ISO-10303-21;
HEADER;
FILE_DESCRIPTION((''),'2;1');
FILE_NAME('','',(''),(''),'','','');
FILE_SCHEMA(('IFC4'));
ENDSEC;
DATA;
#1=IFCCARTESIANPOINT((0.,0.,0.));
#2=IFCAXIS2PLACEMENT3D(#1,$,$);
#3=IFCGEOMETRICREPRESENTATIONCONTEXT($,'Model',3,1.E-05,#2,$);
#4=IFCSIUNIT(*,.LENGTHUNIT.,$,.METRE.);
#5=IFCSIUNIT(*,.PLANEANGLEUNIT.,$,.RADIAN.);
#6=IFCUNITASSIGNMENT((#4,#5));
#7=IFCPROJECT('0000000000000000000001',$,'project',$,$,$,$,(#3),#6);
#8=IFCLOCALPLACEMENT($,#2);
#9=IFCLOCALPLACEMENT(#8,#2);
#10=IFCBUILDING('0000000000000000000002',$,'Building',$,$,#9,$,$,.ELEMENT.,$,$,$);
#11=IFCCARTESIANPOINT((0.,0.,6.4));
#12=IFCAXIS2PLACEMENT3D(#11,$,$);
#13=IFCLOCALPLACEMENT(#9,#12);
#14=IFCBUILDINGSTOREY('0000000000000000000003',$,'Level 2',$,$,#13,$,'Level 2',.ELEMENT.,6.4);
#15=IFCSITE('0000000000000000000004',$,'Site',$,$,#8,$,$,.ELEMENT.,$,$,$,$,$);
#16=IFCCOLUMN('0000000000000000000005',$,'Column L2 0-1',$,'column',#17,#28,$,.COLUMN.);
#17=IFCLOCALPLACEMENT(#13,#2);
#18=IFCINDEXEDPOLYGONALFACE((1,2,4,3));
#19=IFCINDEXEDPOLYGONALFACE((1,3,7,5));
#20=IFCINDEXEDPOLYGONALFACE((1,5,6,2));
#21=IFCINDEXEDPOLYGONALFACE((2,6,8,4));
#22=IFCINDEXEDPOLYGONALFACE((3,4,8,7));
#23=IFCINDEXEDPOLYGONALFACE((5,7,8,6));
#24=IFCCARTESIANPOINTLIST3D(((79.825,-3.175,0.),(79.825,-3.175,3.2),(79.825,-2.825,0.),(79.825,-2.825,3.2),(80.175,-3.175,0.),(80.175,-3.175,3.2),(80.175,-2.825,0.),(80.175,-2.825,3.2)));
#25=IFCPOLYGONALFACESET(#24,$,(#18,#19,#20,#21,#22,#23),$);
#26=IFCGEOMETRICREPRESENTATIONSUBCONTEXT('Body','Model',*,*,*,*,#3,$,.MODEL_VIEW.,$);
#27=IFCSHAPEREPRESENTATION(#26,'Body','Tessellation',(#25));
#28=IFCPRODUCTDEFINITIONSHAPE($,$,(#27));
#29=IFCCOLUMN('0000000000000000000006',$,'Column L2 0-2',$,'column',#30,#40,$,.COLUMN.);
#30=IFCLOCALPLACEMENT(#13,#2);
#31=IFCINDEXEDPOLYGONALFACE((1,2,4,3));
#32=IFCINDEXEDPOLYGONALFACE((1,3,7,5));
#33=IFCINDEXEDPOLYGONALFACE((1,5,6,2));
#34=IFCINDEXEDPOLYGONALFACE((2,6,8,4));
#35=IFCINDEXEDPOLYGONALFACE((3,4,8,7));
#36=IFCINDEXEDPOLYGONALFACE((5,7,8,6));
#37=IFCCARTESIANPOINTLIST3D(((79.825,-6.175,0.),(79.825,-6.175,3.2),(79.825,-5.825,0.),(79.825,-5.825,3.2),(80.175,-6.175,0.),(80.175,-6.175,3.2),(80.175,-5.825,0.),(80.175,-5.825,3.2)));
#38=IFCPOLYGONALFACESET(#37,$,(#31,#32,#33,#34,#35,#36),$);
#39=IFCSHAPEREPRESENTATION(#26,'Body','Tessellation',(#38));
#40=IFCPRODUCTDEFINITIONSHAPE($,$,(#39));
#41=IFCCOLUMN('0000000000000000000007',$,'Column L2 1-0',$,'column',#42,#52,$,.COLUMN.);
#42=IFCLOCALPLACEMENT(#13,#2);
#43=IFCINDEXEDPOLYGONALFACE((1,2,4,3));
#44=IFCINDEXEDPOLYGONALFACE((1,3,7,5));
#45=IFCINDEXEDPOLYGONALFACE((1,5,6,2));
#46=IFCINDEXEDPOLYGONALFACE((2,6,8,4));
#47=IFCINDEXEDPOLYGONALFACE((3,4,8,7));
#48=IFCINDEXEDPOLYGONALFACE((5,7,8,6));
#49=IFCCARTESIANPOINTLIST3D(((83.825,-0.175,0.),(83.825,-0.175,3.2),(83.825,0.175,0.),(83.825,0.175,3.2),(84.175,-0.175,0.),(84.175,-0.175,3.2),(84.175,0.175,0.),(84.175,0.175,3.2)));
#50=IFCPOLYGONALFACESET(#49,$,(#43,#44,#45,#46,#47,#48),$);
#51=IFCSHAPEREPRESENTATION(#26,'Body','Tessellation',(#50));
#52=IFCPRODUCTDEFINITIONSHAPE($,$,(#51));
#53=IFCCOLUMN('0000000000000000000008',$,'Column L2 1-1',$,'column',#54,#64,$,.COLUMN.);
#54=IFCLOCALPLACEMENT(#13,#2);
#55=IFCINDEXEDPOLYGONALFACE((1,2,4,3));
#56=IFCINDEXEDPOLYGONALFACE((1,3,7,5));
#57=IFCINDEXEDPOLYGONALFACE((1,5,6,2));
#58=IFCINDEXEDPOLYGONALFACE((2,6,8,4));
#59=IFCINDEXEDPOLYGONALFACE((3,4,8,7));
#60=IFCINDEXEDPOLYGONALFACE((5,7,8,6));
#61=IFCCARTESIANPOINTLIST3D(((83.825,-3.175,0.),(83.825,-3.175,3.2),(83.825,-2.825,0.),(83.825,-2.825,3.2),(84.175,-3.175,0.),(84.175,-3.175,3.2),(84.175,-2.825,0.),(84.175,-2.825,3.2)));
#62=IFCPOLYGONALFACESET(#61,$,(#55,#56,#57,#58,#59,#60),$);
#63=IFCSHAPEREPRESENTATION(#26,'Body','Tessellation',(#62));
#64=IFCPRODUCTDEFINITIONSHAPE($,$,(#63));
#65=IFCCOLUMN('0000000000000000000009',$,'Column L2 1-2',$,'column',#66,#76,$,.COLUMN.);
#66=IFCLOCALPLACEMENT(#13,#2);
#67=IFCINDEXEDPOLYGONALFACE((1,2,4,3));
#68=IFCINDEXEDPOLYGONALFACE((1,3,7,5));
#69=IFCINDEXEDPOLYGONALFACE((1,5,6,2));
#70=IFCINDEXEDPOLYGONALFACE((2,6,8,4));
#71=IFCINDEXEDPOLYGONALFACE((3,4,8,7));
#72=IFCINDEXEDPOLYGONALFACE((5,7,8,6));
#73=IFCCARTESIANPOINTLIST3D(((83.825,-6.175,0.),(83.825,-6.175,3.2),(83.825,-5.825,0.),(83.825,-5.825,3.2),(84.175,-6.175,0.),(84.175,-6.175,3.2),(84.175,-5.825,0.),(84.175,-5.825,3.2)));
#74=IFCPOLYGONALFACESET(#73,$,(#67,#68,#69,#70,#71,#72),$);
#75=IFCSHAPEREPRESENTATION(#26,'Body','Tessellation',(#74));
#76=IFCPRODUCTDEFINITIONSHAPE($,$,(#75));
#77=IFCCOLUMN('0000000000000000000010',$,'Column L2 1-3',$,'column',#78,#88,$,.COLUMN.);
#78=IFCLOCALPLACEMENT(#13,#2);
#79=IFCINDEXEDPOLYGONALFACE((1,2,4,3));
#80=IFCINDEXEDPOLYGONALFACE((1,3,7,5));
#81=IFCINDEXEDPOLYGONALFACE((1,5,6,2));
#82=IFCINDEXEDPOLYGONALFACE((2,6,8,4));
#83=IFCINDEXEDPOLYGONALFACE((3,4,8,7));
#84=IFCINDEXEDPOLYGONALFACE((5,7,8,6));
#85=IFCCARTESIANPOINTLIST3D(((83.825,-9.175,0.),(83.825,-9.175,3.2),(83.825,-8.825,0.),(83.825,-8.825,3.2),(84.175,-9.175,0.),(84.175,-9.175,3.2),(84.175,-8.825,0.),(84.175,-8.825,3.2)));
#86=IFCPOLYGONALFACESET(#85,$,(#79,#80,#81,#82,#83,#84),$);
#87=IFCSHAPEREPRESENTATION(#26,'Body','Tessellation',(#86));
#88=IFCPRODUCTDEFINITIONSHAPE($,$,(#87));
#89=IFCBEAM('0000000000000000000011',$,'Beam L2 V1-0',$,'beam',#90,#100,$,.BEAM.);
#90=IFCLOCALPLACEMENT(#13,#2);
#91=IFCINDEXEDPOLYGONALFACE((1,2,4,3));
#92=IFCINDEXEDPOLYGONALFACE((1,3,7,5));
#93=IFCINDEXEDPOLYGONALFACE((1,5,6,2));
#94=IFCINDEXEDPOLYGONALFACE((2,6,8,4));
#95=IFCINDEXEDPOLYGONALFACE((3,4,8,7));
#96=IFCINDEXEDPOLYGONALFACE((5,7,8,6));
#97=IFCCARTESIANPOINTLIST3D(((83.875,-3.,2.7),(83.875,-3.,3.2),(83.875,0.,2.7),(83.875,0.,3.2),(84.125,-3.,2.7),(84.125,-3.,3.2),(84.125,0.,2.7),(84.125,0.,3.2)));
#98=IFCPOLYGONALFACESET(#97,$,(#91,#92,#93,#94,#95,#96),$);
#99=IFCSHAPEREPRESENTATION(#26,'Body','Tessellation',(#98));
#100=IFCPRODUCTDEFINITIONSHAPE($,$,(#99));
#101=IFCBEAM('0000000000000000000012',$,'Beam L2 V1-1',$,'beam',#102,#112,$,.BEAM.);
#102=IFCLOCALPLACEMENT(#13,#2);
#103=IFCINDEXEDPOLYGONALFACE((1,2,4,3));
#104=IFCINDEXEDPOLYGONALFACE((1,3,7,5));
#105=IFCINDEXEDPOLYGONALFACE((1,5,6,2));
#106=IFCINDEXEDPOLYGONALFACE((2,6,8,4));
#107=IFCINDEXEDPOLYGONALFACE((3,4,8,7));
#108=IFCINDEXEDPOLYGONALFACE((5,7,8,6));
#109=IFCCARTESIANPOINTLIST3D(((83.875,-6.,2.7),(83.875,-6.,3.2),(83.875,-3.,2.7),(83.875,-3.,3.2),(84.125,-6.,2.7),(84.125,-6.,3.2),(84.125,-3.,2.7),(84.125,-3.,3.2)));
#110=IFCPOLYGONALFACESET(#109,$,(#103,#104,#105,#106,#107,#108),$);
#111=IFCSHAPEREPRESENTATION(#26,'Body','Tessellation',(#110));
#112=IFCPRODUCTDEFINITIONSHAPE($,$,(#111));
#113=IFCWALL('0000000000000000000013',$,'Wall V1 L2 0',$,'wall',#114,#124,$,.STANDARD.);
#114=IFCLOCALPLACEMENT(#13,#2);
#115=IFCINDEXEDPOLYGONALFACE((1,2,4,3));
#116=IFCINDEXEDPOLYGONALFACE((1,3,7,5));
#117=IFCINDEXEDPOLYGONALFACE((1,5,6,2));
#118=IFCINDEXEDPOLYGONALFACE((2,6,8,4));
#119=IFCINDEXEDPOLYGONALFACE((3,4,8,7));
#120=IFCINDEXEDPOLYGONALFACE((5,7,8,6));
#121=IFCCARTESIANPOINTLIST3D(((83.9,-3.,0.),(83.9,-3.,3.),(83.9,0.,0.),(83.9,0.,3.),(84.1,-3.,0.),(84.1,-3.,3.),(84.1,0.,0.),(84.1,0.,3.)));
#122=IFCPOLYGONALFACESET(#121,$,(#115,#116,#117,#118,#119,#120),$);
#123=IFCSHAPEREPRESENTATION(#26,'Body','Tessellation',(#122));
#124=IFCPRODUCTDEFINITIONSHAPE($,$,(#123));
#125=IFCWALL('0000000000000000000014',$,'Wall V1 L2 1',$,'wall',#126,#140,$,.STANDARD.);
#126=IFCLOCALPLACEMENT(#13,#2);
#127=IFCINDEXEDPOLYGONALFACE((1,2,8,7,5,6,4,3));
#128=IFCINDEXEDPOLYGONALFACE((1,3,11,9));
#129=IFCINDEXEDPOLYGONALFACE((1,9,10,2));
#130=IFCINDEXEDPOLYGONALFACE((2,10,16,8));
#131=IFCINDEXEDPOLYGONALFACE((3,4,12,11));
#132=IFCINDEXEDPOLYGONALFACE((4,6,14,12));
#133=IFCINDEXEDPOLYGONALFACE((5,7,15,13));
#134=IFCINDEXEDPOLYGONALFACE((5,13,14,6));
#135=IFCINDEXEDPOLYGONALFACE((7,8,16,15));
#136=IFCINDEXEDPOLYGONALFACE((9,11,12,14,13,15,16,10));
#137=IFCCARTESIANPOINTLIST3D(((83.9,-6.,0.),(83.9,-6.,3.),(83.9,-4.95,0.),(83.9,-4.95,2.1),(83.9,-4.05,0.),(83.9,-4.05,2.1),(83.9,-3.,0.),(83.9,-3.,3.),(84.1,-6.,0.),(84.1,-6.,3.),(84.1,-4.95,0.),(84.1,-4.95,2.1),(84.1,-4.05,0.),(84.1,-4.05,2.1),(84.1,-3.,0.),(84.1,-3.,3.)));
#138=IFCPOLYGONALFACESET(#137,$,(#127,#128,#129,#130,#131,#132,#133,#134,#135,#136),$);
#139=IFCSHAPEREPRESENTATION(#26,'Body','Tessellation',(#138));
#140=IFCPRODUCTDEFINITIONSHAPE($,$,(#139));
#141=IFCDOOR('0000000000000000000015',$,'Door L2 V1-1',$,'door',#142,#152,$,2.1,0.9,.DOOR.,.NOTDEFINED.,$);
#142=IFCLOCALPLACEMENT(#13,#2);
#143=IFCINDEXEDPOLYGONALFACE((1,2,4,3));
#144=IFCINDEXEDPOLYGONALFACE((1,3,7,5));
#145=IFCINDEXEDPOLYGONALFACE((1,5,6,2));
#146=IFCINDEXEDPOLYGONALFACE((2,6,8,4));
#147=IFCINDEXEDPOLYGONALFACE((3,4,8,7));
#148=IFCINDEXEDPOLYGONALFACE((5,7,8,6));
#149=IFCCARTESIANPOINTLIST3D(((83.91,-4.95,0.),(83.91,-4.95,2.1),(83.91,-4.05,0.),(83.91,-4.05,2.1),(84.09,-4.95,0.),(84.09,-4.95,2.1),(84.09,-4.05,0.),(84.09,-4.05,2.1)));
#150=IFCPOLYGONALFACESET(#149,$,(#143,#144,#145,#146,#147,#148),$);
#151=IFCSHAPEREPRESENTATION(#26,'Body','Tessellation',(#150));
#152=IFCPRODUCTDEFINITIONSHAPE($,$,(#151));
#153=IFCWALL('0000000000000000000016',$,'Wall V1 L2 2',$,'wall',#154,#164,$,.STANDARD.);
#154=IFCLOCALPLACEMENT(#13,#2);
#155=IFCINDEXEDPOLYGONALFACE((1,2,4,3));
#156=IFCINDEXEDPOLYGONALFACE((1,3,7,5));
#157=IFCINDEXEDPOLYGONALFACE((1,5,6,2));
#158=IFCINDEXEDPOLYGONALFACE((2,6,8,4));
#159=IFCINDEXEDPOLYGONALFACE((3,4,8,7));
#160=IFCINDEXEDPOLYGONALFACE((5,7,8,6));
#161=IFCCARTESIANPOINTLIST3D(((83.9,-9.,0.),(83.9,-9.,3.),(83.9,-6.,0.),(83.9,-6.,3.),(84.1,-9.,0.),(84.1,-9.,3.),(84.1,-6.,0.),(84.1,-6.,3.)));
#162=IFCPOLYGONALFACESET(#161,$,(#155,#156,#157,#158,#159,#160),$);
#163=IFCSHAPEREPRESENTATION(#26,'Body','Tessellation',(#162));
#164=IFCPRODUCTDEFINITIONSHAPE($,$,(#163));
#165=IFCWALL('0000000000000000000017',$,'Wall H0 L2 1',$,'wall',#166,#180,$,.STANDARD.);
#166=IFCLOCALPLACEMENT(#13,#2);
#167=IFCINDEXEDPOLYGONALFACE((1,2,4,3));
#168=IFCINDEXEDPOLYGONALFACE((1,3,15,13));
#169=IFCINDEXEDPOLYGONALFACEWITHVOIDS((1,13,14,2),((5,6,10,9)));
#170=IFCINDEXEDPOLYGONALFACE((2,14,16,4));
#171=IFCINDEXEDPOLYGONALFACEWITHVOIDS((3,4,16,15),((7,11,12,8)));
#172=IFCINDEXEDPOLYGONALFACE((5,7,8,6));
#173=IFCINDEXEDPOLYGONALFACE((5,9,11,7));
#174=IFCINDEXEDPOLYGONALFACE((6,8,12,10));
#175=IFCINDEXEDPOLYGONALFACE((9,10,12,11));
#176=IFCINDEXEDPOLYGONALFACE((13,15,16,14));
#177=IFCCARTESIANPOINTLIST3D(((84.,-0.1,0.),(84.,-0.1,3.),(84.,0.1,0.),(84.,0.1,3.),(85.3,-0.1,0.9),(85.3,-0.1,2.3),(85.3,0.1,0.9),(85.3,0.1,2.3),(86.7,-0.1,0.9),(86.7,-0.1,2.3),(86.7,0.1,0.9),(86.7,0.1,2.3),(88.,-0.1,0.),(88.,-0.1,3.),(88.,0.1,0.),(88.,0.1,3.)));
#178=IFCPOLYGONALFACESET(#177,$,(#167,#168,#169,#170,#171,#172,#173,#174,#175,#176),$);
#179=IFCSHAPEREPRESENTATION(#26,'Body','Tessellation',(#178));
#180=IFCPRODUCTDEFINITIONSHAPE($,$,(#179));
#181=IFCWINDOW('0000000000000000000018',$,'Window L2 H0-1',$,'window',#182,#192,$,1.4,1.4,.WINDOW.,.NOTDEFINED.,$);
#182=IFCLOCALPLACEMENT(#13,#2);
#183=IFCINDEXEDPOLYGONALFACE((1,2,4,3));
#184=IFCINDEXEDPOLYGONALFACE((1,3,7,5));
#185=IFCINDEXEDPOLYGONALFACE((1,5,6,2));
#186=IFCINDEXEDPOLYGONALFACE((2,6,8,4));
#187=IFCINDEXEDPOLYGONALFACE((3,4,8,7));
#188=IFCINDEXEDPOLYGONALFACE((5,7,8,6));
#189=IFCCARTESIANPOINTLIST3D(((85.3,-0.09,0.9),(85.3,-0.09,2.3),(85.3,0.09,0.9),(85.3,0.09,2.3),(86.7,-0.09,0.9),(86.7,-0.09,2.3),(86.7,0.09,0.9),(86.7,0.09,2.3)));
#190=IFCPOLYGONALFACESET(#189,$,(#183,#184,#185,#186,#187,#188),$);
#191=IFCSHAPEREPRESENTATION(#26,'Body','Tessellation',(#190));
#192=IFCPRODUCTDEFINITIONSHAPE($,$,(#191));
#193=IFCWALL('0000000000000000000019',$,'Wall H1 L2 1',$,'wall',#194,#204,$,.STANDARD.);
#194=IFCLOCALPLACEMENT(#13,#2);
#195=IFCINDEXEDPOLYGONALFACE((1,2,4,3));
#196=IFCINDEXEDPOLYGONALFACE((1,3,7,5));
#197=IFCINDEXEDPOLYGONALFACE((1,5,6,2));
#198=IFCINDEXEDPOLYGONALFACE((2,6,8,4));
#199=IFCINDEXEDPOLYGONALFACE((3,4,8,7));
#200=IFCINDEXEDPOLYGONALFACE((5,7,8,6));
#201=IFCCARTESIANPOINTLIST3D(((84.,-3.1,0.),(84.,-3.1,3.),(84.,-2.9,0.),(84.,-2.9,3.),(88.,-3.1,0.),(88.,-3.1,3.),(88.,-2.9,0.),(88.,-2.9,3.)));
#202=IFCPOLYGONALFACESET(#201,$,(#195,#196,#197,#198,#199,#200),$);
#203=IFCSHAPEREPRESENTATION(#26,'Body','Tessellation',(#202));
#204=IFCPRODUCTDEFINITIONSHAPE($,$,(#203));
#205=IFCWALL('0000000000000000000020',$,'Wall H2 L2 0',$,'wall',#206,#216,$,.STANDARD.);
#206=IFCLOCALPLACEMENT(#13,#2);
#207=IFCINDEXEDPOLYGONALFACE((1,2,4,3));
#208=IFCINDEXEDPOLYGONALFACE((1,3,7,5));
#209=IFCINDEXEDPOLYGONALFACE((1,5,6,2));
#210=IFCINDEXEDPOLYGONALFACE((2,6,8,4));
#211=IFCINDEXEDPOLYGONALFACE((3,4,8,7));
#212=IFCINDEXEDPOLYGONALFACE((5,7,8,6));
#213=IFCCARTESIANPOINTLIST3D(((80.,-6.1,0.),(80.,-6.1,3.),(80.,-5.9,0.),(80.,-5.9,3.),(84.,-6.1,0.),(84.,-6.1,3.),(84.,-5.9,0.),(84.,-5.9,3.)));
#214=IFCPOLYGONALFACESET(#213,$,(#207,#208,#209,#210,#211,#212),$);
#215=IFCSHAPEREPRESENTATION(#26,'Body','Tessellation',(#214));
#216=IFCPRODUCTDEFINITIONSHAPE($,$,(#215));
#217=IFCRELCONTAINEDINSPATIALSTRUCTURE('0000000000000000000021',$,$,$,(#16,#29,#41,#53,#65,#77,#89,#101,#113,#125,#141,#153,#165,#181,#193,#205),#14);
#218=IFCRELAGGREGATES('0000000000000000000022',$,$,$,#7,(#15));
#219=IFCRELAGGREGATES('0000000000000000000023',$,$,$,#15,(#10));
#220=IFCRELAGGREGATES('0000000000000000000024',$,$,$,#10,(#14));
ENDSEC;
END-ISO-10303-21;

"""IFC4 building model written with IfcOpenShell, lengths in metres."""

from ifc_helpers import new_model, si_unit, frame, frame_2d, origin, origin_2d, place, context, subcontext, project, spatial, rectangle, extrude, element, fill, save


model = new_model("IFC4")

# Units and contexts
model_context = context("Model", 3, precision=1e-05, world=origin())
body_context = subcontext(model_context, "Body", "Model", "MODEL_VIEW")
ifc_project = project(units=[si_unit("LENGTHUNIT", "METRE"), si_unit("PLANEANGLEUNIT", "RADIAN")], contexts=[model_context])

# Site, building, storey
site_placement = place(None, origin())
site = spatial("IfcSite", under=ifc_project, at=site_placement, Name="Site", CompositionType="ELEMENT")
building_placement = place(site_placement, origin())
building = spatial("IfcBuilding", under=site, at=building_placement, Name="Building", CompositionType="ELEMENT")
storey_placement = place(building_placement, frame((0.0, 0.0, 6.4)))
storey = spatial("IfcBuildingStorey", under=building, at=storey_placement, Name="Level 2", LongName="Level 2", CompositionType="ELEMENT", Elevation=6.4)

# Columns
for number, where, name in (
    (1, (80.0, -3.0, 0.0), "Column L2 0-1"),
    (2, (80.0, -6.0, 0.0), "Column L2 0-2"),
    (3, (84.0, 0.0, 0.0), "Column L2 1-0"),
    (4, (84.0, -3.0, 0.0), "Column L2 1-1"),
    (5, (84.0, -6.0, 0.0), "Column L2 1-2"),
    (6, (84.0, -9.0, 0.0), "Column L2 1-3"),
):
    element("IfcColumn", number, at=place(storey_placement, frame(where)), inside=storey, Name=name, ObjectType="column", PredefinedType="COLUMN", context=body_context, shape_type="SweptSolid", body=[
        extrude(rectangle(XDim=0.35, YDim=0.35, at=origin_2d()), origin(), (0.0, 0.0, 1.0), 3.2),
    ])

# Beams
for number, where, z_axis, x_axis, name in (
    (7, (84.0, 0.0, 2.95), (0.0, -1.0, 0.0), (0.0, 0.0, 1.0), "Beam L2 V1-0"),
    (8, (84.0, -3.0, 2.95), (0.0, -1.0, 0.0), (0.0, 0.0, 1.0), "Beam L2 V1-1"),
):
    element("IfcBeam", number, at=place(storey_placement, frame(where, z_axis=z_axis, x_axis=x_axis)), inside=storey, Name=name, ObjectType="beam", PredefinedType="BEAM", context=body_context, shape_type="SweptSolid", body=[
        extrude(rectangle(XDim=0.5, YDim=0.25, at=origin_2d()), origin(), (0.0, 0.0, 1.0), 3.0),
    ])

# Wall
wall_1_placement = place(storey_placement, frame((84.0, 0.0, 0.0), z_axis=(0.0, 0.0, 1.0), x_axis=(0.0, -1.0, 0.0)))
element("IfcWall", 9, at=wall_1_placement, inside=storey, Name="Wall V1 L2 0", ObjectType="wall", PredefinedType="STANDARD", context=body_context, shape_type="SweptSolid", body=[
    extrude(rectangle(XDim=3.0, YDim=0.2, at=frame_2d((1.5, 0.0))), origin(), (0.0, 0.0, 1.0), 3.0),
])

# Wall, opening, door
wall_2_placement = place(storey_placement, frame((84.0, -3.0, 0.0), z_axis=(0.0, 0.0, 1.0), x_axis=(0.0, -1.0, 0.0)))
wall_2 = element("IfcWall", 10, at=wall_2_placement, inside=storey, Name="Wall V1 L2 1", ObjectType="wall", PredefinedType="STANDARD", context=body_context, shape_type="SweptSolid", body=[
    extrude(rectangle(XDim=3.0, YDim=0.2, at=frame_2d((1.5, 0.0))), origin(), (0.0, 0.0, 1.0), 3.0),
])
opening_1_placement = place(storey_placement, frame((84.0, -4.5, 0.0), z_axis=(0.0, 0.0, 1.0), x_axis=(0.0, -1.0, 0.0)))
opening_1 = element("IfcOpeningElement", 11, at=opening_1_placement, cuts=wall_2, ObjectType="Opening", PredefinedType="OPENING", context=body_context, shape_type="SweptSolid", body=[
    extrude(rectangle(XDim=0.9, YDim=0.22, at=origin_2d()), origin(), (0.0, 0.0, 1.0), 2.1),
])
door_placement = place(storey_placement, frame((84.0, -4.5, 0.0), z_axis=(0.0, 0.0, 1.0), x_axis=(0.0, -1.0, 0.0)))
door = element("IfcDoor", 12, at=door_placement, inside=storey, Name="Door L2 V1-1", ObjectType="door", OperationType="NOTDEFINED", OverallHeight=2.1, OverallWidth=0.9, PredefinedType="DOOR", context=body_context, shape_type="SweptSolid", body=[
    extrude(rectangle(XDim=0.9, YDim=0.18, at=origin_2d()), origin(), (0.0, 0.0, 1.0), 2.1),
])
fill(opening_1, door)

# Wall
wall_3_placement = place(storey_placement, frame((84.0, -6.0, 0.0), z_axis=(0.0, 0.0, 1.0), x_axis=(0.0, -1.0, 0.0)))
element("IfcWall", 13, at=wall_3_placement, inside=storey, Name="Wall V1 L2 2", ObjectType="wall", PredefinedType="STANDARD", context=body_context, shape_type="SweptSolid", body=[
    extrude(rectangle(XDim=3.0, YDim=0.2, at=frame_2d((1.5, 0.0))), origin(), (0.0, 0.0, 1.0), 3.0),
])

# Wall, opening, window
wall_4_placement = place(storey_placement, frame((84.0, 0.0, 0.0), z_axis=(0.0, 0.0, 1.0), x_axis=(1.0, 0.0, 0.0)))
wall_4 = element("IfcWall", 14, at=wall_4_placement, inside=storey, Name="Wall H0 L2 1", ObjectType="wall", PredefinedType="STANDARD", context=body_context, shape_type="SweptSolid", body=[
    extrude(rectangle(XDim=4.0, YDim=0.2, at=frame_2d((2.0, 0.0))), origin(), (0.0, 0.0, 1.0), 3.0),
])
opening_2_placement = place(storey_placement, frame((86.0, 0.0, 0.9), z_axis=(0.0, 0.0, 1.0), x_axis=(1.0, 0.0, 0.0)))
opening_2 = element("IfcOpeningElement", 15, at=opening_2_placement, cuts=wall_4, ObjectType="Opening", PredefinedType="OPENING", context=body_context, shape_type="SweptSolid", body=[
    extrude(rectangle(XDim=1.4, YDim=0.22, at=origin_2d()), origin(), (0.0, 0.0, 1.0), 1.4),
])
window_1_placement = place(storey_placement, frame((86.0, 0.0, 0.9), z_axis=(0.0, 0.0, 1.0), x_axis=(1.0, 0.0, 0.0)))
window_1 = element("IfcWindow", 16, at=window_1_placement, inside=storey, Name="Window L2 H0-1", ObjectType="window", OverallHeight=1.4, OverallWidth=1.4, PartitioningType="NOTDEFINED", PredefinedType="WINDOW", context=body_context, shape_type="SweptSolid", body=[
    extrude(rectangle(XDim=1.4, YDim=0.18, at=origin_2d()), origin(), (0.0, 0.0, 1.0), 1.4),
])
fill(opening_2, window_1)

# Walls
for number, where, z_axis, x_axis, name in (
    (17, (84.0, -3.0, 0.0), (0.0, 0.0, 1.0), (1.0, 0.0, 0.0), "Wall H1 L2 1"),
    (18, (80.0, -6.0, 0.0), (0.0, 0.0, 1.0), (1.0, 0.0, 0.0), "Wall H2 L2 0"),
):
    element("IfcWall", number, at=place(storey_placement, frame(where, z_axis=z_axis, x_axis=x_axis)), inside=storey, Name=name, ObjectType="wall", PredefinedType="STANDARD", context=body_context, shape_type="SweptSolid", body=[
        extrude(rectangle(XDim=4.0, YDim=0.2, at=frame_2d((2.0, 0.0))), origin(), (0.0, 0.0, 1.0), 3.0),
    ])

save(model, "model.ifc")
